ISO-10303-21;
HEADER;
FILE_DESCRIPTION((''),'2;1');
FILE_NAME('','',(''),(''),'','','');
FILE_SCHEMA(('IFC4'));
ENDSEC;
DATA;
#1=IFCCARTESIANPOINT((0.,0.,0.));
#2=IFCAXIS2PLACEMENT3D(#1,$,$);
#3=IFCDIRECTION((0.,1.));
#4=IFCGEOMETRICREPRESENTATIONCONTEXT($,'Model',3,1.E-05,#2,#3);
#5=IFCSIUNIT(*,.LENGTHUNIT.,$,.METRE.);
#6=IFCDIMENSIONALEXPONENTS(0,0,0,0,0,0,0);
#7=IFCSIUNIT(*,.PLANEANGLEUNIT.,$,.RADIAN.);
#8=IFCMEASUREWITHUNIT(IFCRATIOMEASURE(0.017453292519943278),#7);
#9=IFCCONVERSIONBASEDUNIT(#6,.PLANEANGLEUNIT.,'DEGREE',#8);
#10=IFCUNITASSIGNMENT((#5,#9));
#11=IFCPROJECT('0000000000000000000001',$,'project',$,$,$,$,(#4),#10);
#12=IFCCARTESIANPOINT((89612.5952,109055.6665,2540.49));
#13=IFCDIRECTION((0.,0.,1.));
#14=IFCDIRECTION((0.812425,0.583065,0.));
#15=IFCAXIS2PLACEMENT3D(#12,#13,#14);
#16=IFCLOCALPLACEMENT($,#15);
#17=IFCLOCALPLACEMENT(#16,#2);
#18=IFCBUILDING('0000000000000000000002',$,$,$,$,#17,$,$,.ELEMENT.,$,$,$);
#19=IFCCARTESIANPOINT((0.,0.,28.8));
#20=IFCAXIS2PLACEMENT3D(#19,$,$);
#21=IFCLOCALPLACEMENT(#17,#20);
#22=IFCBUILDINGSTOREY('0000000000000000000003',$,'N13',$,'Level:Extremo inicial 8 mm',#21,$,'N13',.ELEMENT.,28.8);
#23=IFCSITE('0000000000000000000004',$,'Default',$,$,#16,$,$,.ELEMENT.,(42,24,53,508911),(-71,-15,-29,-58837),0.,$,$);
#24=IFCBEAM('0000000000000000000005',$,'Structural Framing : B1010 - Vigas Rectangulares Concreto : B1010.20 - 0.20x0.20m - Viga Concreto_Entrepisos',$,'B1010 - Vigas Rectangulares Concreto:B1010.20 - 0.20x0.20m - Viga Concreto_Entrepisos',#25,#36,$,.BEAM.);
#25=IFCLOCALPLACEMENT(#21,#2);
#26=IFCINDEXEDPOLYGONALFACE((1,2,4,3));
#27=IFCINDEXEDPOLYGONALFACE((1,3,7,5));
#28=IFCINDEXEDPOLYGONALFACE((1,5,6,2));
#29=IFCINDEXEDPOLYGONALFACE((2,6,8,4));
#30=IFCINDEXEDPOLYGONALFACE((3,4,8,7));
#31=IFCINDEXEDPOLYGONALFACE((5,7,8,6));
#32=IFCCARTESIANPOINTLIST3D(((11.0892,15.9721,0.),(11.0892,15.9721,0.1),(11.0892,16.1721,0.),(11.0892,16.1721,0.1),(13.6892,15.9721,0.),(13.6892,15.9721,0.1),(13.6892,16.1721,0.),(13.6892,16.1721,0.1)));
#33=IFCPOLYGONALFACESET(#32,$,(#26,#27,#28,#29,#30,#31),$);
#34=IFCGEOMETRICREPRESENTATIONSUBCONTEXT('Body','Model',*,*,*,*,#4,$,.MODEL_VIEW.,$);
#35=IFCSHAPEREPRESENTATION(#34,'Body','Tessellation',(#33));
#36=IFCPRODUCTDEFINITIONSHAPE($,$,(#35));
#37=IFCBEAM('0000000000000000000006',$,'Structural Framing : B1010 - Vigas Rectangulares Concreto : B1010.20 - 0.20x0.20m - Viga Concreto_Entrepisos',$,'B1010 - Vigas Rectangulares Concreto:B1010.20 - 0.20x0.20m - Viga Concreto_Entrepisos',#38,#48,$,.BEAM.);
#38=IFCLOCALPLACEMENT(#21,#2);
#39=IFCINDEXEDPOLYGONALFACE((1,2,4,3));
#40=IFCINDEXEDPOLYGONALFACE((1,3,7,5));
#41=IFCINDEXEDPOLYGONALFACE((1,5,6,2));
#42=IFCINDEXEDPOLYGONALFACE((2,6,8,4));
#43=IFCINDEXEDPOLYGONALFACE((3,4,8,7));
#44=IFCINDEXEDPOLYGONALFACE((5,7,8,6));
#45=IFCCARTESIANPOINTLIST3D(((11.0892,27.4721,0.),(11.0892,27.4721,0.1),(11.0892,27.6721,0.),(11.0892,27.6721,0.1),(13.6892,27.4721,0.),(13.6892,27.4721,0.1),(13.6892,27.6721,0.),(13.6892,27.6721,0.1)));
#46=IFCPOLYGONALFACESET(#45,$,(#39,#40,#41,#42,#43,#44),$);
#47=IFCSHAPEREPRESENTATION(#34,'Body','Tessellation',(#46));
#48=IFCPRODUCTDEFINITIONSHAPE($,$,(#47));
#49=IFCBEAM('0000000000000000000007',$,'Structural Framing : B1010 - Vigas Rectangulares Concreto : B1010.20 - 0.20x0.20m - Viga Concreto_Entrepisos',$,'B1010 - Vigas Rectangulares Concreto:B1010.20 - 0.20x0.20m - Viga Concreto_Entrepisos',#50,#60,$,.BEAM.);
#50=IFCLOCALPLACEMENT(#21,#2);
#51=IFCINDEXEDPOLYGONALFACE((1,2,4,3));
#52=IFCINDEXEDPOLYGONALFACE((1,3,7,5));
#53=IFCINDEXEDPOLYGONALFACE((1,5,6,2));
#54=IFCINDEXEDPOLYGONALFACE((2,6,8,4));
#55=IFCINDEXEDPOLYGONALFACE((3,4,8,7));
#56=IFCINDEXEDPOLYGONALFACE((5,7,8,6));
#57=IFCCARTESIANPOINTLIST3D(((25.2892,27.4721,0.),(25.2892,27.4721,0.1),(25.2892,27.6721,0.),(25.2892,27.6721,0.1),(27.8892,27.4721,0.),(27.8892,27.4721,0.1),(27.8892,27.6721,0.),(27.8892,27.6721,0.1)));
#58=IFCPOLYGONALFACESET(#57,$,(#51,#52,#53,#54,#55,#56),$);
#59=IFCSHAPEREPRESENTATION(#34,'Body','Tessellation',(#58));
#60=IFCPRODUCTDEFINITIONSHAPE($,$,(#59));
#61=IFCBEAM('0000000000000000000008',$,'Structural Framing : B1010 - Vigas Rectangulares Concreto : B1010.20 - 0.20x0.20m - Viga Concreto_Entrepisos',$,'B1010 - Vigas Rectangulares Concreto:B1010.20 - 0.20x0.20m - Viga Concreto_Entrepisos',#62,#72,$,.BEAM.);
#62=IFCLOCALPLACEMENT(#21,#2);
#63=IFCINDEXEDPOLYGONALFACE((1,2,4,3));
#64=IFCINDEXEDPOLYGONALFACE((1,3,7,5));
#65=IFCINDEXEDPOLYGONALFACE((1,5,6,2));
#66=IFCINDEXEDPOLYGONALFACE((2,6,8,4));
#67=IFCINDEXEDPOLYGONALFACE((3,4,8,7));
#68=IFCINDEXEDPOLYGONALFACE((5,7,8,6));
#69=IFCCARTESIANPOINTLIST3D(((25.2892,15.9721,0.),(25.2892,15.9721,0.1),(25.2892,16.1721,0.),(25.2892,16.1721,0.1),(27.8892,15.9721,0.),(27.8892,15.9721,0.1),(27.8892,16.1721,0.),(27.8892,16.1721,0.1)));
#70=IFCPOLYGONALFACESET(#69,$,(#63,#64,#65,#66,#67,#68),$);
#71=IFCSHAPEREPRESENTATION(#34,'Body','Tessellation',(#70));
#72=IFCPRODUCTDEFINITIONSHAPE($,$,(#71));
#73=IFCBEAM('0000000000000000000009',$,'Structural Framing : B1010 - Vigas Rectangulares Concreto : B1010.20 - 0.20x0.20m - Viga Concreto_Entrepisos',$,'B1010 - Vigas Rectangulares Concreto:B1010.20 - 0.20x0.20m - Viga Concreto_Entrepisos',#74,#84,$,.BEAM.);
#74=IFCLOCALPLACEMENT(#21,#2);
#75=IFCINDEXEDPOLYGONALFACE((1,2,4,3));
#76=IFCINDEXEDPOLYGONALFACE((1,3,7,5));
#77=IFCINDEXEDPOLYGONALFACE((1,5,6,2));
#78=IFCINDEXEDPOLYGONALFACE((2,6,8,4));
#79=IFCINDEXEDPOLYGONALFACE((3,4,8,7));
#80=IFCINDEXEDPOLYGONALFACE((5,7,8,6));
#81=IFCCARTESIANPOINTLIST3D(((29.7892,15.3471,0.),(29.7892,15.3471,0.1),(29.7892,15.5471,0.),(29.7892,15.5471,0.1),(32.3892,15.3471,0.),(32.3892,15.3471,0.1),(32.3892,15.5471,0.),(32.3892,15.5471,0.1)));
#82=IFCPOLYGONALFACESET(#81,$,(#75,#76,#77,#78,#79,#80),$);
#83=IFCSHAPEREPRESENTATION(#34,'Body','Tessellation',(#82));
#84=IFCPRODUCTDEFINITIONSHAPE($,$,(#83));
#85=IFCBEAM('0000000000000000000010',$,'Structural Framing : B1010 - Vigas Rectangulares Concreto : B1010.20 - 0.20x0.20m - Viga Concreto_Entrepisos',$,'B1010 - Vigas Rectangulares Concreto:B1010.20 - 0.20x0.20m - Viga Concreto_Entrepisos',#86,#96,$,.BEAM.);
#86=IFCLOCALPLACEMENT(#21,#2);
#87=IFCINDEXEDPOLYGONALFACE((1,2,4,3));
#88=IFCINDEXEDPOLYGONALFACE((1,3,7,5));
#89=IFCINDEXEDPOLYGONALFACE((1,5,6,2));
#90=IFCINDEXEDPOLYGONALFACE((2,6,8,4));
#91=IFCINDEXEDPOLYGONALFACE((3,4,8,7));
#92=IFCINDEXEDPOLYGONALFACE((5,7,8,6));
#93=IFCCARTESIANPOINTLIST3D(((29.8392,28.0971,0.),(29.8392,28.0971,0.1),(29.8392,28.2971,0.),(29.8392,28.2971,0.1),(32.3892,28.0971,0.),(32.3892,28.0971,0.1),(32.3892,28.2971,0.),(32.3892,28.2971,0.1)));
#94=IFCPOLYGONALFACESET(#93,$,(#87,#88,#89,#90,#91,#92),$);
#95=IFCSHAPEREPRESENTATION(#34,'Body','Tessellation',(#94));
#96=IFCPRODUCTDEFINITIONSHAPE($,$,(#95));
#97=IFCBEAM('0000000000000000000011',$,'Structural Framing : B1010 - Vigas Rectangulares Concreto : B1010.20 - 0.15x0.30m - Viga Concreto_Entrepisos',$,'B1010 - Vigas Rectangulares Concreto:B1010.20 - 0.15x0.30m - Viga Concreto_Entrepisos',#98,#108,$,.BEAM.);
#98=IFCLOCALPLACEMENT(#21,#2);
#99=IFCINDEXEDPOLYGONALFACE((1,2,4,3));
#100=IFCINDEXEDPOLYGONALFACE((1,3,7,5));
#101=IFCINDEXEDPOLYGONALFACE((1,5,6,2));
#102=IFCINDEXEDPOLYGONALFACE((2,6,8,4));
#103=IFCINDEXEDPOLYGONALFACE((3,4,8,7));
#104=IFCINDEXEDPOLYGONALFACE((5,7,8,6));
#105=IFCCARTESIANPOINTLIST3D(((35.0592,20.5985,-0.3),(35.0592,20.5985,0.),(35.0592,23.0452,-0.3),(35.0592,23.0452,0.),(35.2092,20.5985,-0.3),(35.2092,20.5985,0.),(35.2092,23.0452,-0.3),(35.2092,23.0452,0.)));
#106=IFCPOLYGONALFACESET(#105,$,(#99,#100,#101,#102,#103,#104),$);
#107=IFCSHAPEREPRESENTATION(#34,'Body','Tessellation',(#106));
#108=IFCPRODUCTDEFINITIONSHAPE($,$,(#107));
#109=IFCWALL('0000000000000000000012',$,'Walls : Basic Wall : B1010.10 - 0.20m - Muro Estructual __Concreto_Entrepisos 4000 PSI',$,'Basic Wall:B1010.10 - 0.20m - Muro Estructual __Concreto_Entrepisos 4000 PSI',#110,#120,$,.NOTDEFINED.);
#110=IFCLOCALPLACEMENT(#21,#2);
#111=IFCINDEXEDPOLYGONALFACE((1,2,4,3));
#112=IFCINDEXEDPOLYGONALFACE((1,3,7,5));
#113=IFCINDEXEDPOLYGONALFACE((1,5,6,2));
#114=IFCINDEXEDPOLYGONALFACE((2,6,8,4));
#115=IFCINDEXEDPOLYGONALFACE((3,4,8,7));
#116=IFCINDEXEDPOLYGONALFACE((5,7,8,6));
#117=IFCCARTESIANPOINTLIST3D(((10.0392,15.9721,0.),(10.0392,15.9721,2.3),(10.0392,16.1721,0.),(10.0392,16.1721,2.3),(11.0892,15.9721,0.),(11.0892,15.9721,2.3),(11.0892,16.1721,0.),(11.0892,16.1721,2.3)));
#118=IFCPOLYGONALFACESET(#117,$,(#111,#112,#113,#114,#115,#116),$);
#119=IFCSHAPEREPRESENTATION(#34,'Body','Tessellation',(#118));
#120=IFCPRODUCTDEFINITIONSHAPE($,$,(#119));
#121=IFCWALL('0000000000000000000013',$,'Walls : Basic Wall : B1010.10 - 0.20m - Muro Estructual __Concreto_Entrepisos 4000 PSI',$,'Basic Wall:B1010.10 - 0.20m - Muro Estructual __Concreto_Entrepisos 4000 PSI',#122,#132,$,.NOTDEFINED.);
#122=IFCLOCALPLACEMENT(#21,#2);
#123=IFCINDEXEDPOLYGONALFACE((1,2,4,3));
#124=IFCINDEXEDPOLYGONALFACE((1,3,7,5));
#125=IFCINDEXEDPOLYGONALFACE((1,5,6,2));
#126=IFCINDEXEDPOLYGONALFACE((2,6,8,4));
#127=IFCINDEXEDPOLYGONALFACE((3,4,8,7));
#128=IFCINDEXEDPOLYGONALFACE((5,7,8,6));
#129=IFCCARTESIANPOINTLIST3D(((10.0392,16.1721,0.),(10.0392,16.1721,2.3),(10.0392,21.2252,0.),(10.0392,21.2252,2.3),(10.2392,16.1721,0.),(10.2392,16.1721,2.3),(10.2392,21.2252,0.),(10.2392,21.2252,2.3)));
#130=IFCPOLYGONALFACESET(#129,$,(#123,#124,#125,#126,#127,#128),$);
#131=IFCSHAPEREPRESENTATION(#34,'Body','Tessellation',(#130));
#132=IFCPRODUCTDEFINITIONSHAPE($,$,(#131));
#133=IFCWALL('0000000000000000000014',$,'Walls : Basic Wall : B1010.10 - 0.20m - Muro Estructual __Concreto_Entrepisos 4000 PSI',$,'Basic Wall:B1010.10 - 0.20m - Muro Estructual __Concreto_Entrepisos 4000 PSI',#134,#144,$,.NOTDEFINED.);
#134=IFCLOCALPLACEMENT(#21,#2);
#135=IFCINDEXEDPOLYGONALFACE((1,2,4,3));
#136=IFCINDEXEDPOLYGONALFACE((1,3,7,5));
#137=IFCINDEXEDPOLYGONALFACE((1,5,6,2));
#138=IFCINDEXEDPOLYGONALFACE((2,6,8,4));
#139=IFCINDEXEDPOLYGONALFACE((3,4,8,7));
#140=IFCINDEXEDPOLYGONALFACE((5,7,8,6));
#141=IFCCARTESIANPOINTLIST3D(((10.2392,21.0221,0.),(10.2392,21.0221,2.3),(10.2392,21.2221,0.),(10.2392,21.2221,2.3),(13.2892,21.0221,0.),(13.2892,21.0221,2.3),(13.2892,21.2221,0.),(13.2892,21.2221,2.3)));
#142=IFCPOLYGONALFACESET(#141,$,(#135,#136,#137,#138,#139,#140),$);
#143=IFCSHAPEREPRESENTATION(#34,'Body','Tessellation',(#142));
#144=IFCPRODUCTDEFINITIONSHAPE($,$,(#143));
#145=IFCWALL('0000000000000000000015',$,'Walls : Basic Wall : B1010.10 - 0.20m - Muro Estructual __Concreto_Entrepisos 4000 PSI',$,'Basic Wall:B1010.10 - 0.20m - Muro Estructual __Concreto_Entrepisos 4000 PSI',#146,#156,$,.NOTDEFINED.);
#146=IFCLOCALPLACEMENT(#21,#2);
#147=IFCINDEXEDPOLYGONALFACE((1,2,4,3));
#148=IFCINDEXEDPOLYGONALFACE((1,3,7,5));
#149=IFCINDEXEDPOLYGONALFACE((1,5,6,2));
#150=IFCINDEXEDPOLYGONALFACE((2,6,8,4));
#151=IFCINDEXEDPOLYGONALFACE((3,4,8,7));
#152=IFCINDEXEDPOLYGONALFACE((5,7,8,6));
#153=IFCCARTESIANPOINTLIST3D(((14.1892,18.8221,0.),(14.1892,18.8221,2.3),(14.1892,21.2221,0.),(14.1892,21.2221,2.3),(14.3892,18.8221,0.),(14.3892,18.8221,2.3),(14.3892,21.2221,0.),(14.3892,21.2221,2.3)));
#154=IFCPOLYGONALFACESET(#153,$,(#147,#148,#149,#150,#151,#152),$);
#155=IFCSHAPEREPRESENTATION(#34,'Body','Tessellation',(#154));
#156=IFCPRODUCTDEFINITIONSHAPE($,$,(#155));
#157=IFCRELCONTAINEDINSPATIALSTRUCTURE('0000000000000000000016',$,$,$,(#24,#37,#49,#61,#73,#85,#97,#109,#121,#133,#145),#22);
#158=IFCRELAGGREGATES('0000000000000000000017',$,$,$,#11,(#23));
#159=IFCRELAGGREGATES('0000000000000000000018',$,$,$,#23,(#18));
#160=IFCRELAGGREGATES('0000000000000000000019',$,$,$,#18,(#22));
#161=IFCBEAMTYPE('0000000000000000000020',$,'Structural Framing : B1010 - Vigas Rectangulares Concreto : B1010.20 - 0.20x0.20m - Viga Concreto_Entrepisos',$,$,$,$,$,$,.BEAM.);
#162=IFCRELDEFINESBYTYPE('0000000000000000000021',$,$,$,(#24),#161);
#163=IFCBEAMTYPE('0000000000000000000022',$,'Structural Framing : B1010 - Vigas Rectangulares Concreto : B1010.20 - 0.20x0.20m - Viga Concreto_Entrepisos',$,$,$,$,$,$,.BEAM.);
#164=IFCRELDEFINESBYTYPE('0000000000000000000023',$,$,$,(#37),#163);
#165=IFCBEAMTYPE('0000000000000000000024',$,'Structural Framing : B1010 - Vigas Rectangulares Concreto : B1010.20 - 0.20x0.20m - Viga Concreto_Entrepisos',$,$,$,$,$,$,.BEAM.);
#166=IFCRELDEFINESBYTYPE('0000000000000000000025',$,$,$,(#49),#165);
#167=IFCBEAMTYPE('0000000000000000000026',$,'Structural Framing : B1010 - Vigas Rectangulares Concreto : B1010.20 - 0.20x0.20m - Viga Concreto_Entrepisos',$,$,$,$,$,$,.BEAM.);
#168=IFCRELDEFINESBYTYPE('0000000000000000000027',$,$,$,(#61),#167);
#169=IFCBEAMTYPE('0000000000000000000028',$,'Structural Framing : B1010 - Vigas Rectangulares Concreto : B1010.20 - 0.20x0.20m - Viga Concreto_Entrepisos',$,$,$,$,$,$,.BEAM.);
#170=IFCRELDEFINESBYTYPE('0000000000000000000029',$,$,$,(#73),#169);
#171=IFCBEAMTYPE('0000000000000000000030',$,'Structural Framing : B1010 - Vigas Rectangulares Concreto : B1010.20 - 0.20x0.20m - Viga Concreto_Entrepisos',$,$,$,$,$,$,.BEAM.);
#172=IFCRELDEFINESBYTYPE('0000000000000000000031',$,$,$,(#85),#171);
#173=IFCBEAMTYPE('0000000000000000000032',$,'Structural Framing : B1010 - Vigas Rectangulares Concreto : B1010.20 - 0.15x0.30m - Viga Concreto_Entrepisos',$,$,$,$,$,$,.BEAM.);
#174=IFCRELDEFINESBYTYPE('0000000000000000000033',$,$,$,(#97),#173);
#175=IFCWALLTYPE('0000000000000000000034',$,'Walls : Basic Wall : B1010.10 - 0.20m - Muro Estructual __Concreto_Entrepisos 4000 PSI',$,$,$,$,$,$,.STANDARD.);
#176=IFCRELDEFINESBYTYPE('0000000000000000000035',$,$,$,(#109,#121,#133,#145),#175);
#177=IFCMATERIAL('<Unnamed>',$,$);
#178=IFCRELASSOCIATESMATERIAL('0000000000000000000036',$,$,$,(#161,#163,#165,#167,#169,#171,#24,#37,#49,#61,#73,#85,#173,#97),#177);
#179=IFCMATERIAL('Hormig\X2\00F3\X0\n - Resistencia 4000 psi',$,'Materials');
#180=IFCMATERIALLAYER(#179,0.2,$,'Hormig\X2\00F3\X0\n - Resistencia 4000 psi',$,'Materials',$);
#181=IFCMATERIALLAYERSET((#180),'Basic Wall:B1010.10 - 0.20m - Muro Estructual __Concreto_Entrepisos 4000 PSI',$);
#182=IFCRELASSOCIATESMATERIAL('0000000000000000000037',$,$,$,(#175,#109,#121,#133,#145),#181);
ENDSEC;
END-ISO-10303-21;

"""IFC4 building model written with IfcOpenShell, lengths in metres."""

from ifc_helpers import new_model, entity, si_unit, converted_unit, direction, frame, frame_2d, origin, place, context, subcontext, project, spatial, polyline, segment, composite_curve, rectangle, outline, extrude, source, transform, mapped, material, layer, layer_set, layer_usage, material_profile, profile_set, profile_usage, type_object, type_shapes, element, save


model = new_model("IFC4")

# Units and contexts
model_context = context("Model", 3, precision=1e-05, world=origin(), true_north=direction((0.0, 1.0)))
body_context = subcontext(model_context, "Body", "Model", "MODEL_VIEW")
ifc_project = project(units=[si_unit("LENGTHUNIT", "METRE"), converted_unit("PLANEANGLEUNIT", "DEGREE", entity("IfcRatioMeasure", 0.017453292519943278), si_unit("PLANEANGLEUNIT", "RADIAN"), dimensions=[0, 0, 0, 0, 0, 0, 0])], contexts=[model_context])

# Site, building, storey
site_placement = place(None, frame((89612.5952, 109055.6665, 2540.49), z_axis=(0.0, 0.0, 1.0), x_axis=(0.812425, 0.583065, 0.0)))
site = spatial("IfcSite", under=ifc_project, at=site_placement, Name="Default", CompositionType="ELEMENT", RefLatitude=(42, 24, 53, 508911), RefLongitude=(-71, -15, -29, -58837), RefElevation=0.0)
building_placement = place(site_placement, origin())
building = spatial("IfcBuilding", under=site, at=building_placement, CompositionType="ELEMENT")
storey_placement = place(building_placement, frame((0.0, 0.0, 28.8)))
storey = spatial("IfcBuildingStorey", under=building, at=storey_placement, Name="N13", ObjectType="Level:Extremo inicial 8 mm", LongName="N13", CompositionType="ELEMENT", Elevation=28.8)

# Beams
ifc_material_1 = material(Name="<Unnamed>")
ifc_material_profile_1 = material_profile(ifc_material_1, outline(composite_curve([segment(polyline([(-0.1, 0.0, 0.0), (-0.1, 0.1, 0.0)]), True, "CONTINUOUS"), segment(polyline([(-0.1, 0.1, 0.0), (0.1, 0.1, 0.0)]), True, "CONTINUOUS"), segment(polyline([(0.1, 0.1, 0.0), (0.1, 0.0, 0.0)]), True, "CONTINUOUS"), segment(polyline([(0.1, 0.0, 0.0), (-0.1, 0.0, 0.0)]), True, "CONTINUOUS")], self_intersect=False), kind="CURVE"), Name="B1010.20 - 0.20x0.20m - Viga Concreto_Entrepisos")
ifc_material_profile_2 = material_profile(ifc_material_1, outline(composite_curve([segment(polyline([(-1.3, -0.1, 0.1), (-1.3, 0.1, 0.1)]), True, "CONTINUOUS"), segment(polyline([(-1.3, 0.1, 0.1), (-1.3, 0.1, -0.1)]), True, "CONTINUOUS"), segment(polyline([(-1.3, 0.1, -0.1), (-1.3, -0.1, -0.1)]), True, "CONTINUOUS"), segment(polyline([(-1.3, -0.1, -0.1), (-1.3, -0.1, 0.1)]), True, "CONTINUOUS")], self_intersect=False), kind="CURVE"), Name="B1010.20 - 0.20x0.20m - Viga Concreto_Entrepisos")
ifc_profile_set_1 = profile_set([ifc_material_profile_1, ifc_material_profile_2], Name="B1010.20 - 0.20x0.20m - Viga Concreto_Entrepisos")
ifc_profile_usage_1 = profile_usage(ifc_profile_set_1, cardinal=8)
beam_type_1 = type_object("IfcBeamType", Name="Structural Framing : B1010 - Vigas Rectangulares Concreto : B1010.20 - 0.20x0.20m - Viga Concreto_Entrepisos", PredefinedType="BEAM", material=ifc_profile_set_1)
shared_shape_1 = source(origin(), body_context, "Body", "SweptSolid", [
    extrude(rectangle(XDim=0.1, YDim=0.2, at=frame_2d((0.0, 0.0), x_axis=(1.0, 0.0))), frame((13.6892, 16.0721, 28.85), z_axis=(-1.0, 0.0, 0.0), x_axis=(0.0, 0.0, -1.0)), (0.0, 0.0, 1.0), 2.6),
])
type_shapes(beam_type_1, [shared_shape_1])
beam_1_placement = place(storey_placement, frame((0.0, 0.0, -28.8)))
element("IfcBeam", 1, at=beam_1_placement, inside=storey, type_object=beam_type_1, material=ifc_profile_usage_1, Name="Structural Framing : B1010 - Vigas Rectangulares Concreto : B1010.20 - 0.20x0.20m - Viga Concreto_Entrepisos", ObjectType="B1010 - Vigas Rectangulares Concreto:B1010.20 - 0.20x0.20m - Viga Concreto_Entrepisos", PredefinedType="BEAM", context=body_context, shape_type="MappedRepresentation", body=[
    mapped(shared_shape_1, transform((0.0, 0.0, 0.0), scale=1.0)),
])
ifc_profile_usage_2 = profile_usage(ifc_profile_set_1, cardinal=8)
beam_type_2 = type_object("IfcBeamType", Name="Structural Framing : B1010 - Vigas Rectangulares Concreto : B1010.20 - 0.20x0.20m - Viga Concreto_Entrepisos", PredefinedType="BEAM", material=ifc_profile_set_1)
shared_shape_2 = source(origin(), body_context, "Body", "SweptSolid", [
    extrude(rectangle(XDim=0.1, YDim=0.2, at=frame_2d((0.0, 0.0), x_axis=(1.0, 0.0))), frame((13.6892, 27.5721, 28.85), z_axis=(-1.0, 0.0, 0.0), x_axis=(0.0, 0.0, -1.0)), (0.0, 0.0, 1.0), 2.6),
])
type_shapes(beam_type_2, [shared_shape_2])
beam_2_placement = place(storey_placement, frame((0.0, 0.0, -28.8)))
element("IfcBeam", 2, at=beam_2_placement, inside=storey, type_object=beam_type_2, material=ifc_profile_usage_2, Name="Structural Framing : B1010 - Vigas Rectangulares Concreto : B1010.20 - 0.20x0.20m - Viga Concreto_Entrepisos", ObjectType="B1010 - Vigas Rectangulares Concreto:B1010.20 - 0.20x0.20m - Viga Concreto_Entrepisos", PredefinedType="BEAM", context=body_context, shape_type="MappedRepresentation", body=[
    mapped(shared_shape_2, transform((0.0, 0.0, 0.0), scale=1.0)),
])
ifc_profile_usage_3 = profile_usage(ifc_profile_set_1, cardinal=8)
beam_type_3 = type_object("IfcBeamType", Name="Structural Framing : B1010 - Vigas Rectangulares Concreto : B1010.20 - 0.20x0.20m - Viga Concreto_Entrepisos", PredefinedType="BEAM", material=ifc_profile_set_1)
shared_shape_3 = source(origin(), body_context, "Body", "SweptSolid", [
    extrude(rectangle(XDim=0.1, YDim=0.2, at=frame_2d((0.0, 0.0), x_axis=(1.0, 0.0))), frame((25.2892, 27.5721, 28.85), z_axis=(1.0, 0.0, 0.0), x_axis=(0.0, 0.0, -1.0)), (0.0, 0.0, 1.0), 2.6),
])
type_shapes(beam_type_3, [shared_shape_3])
beam_3_placement = place(storey_placement, frame((0.0, 0.0, -28.8)))
element("IfcBeam", 3, at=beam_3_placement, inside=storey, type_object=beam_type_3, material=ifc_profile_usage_3, Name="Structural Framing : B1010 - Vigas Rectangulares Concreto : B1010.20 - 0.20x0.20m - Viga Concreto_Entrepisos", ObjectType="B1010 - Vigas Rectangulares Concreto:B1010.20 - 0.20x0.20m - Viga Concreto_Entrepisos", PredefinedType="BEAM", context=body_context, shape_type="MappedRepresentation", body=[
    mapped(shared_shape_3, transform((0.0, 0.0, 0.0), scale=1.0)),
])
ifc_profile_usage_4 = profile_usage(ifc_profile_set_1, cardinal=8)
beam_type_4 = type_object("IfcBeamType", Name="Structural Framing : B1010 - Vigas Rectangulares Concreto : B1010.20 - 0.20x0.20m - Viga Concreto_Entrepisos", PredefinedType="BEAM", material=ifc_profile_set_1)
shared_shape_4 = source(origin(), body_context, "Body", "SweptSolid", [
    extrude(rectangle(XDim=0.1, YDim=0.2, at=frame_2d((0.0, 0.0), x_axis=(1.0, 0.0))), frame((25.2892, 16.0721, 28.85), z_axis=(1.0, 0.0, 0.0), x_axis=(0.0, 0.0, -1.0)), (0.0, 0.0, 1.0), 2.6),
])
type_shapes(beam_type_4, [shared_shape_4])
beam_4_placement = place(storey_placement, frame((0.0, 0.0, -28.8)))
element("IfcBeam", 4, at=beam_4_placement, inside=storey, type_object=beam_type_4, material=ifc_profile_usage_4, Name="Structural Framing : B1010 - Vigas Rectangulares Concreto : B1010.20 - 0.20x0.20m - Viga Concreto_Entrepisos", ObjectType="B1010 - Vigas Rectangulares Concreto:B1010.20 - 0.20x0.20m - Viga Concreto_Entrepisos", PredefinedType="BEAM", context=body_context, shape_type="MappedRepresentation", body=[
    mapped(shared_shape_4, transform((0.0, 0.0, 0.0), scale=1.0)),
])
ifc_profile_usage_5 = profile_usage(ifc_profile_set_1, cardinal=8)
beam_type_5 = type_object("IfcBeamType", Name="Structural Framing : B1010 - Vigas Rectangulares Concreto : B1010.20 - 0.20x0.20m - Viga Concreto_Entrepisos", PredefinedType="BEAM", material=ifc_profile_set_1)
shared_shape_5 = source(origin(), body_context, "Body", "SweptSolid", [
    extrude(rectangle(XDim=0.1, YDim=0.2, at=frame_2d((0.0, 0.0), x_axis=(1.0, 0.0))), frame((32.3892, 15.4471, 28.85), z_axis=(-1.0, 0.0, 0.0), x_axis=(0.0, 0.0, -1.0)), (0.0, 0.0, 1.0), 2.6),
])
type_shapes(beam_type_5, [shared_shape_5])
beam_5_placement = place(storey_placement, frame((0.0, 0.0, -28.8)))
element("IfcBeam", 5, at=beam_5_placement, inside=storey, type_object=beam_type_5, material=ifc_profile_usage_5, Name="Structural Framing : B1010 - Vigas Rectangulares Concreto : B1010.20 - 0.20x0.20m - Viga Concreto_Entrepisos", ObjectType="B1010 - Vigas Rectangulares Concreto:B1010.20 - 0.20x0.20m - Viga Concreto_Entrepisos", PredefinedType="BEAM", context=body_context, shape_type="MappedRepresentation", body=[
    mapped(shared_shape_5, transform((0.0, 0.0, 0.0), scale=1.0)),
])
ifc_profile_usage_6 = profile_usage(ifc_profile_set_1, cardinal=8)
beam_type_6 = type_object("IfcBeamType", Name="Structural Framing : B1010 - Vigas Rectangulares Concreto : B1010.20 - 0.20x0.20m - Viga Concreto_Entrepisos", PredefinedType="BEAM", material=ifc_profile_set_1)
shared_shape_6 = source(origin(), body_context, "Body", "SweptSolid", [
    extrude(rectangle(XDim=0.1, YDim=0.2, at=frame_2d((0.0, 0.0), x_axis=(1.0, 0.0))), frame((29.8392, 28.1971, 28.85), z_axis=(1.0, 0.0, 0.0), x_axis=(0.0, 0.0, -1.0)), (0.0, 0.0, 1.0), 2.55),
])
type_shapes(beam_type_6, [shared_shape_6])
beam_6_placement = place(storey_placement, frame((0.0, 0.0, -28.8)))
element("IfcBeam", 6, at=beam_6_placement, inside=storey, type_object=beam_type_6, material=ifc_profile_usage_6, Name="Structural Framing : B1010 - Vigas Rectangulares Concreto : B1010.20 - 0.20x0.20m - Viga Concreto_Entrepisos", ObjectType="B1010 - Vigas Rectangulares Concreto:B1010.20 - 0.20x0.20m - Viga Concreto_Entrepisos", PredefinedType="BEAM", context=body_context, shape_type="MappedRepresentation", body=[
    mapped(shared_shape_6, transform((0.0, 0.0, 0.0), scale=1.0)),
])
ifc_material_profile_3 = material_profile(ifc_material_1, outline(composite_curve([segment(polyline([(-0.075, -0.15, 0.0), (-0.075, 0.15, 0.0)]), True, "CONTINUOUS"), segment(polyline([(-0.075, 0.15, 0.0), (0.075, 0.15, 0.0)]), True, "CONTINUOUS"), segment(polyline([(0.075, 0.15, 0.0), (0.075, -0.15, 0.0)]), True, "CONTINUOUS"), segment(polyline([(0.075, -0.15, 0.0), (-0.075, -0.15, 0.0)]), True, "CONTINUOUS")], self_intersect=False), kind="CURVE"), Name="B1010.20 - 0.15x0.30m - Viga Concreto_Entrepisos")
ifc_material_profile_4 = material_profile(ifc_material_1, outline(composite_curve([segment(polyline([(1.2233, 0.075, 0.15), (1.2233, 0.075, -0.15)]), True, "CONTINUOUS"), segment(polyline([(1.2233, 0.075, -0.15), (-1.2233, 0.075, -0.15)]), True, "CONTINUOUS"), segment(polyline([(-1.2233, 0.075, -0.15), (-1.2233, 0.075, 0.15)]), True, "CONTINUOUS"), segment(polyline([(-1.2233, 0.075, 0.15), (1.2233, 0.075, 0.15)]), True, "CONTINUOUS")], self_intersect=False), kind="CURVE"), Name="B1010.20 - 0.15x0.30m - Viga Concreto_Entrepisos")
ifc_profile_set_2 = profile_set([ifc_material_profile_3, ifc_material_profile_4], Name="B1010.20 - 0.15x0.30m - Viga Concreto_Entrepisos")
ifc_profile_usage_7 = profile_usage(ifc_profile_set_2, cardinal=8)
beam_type_7 = type_object("IfcBeamType", Name="Structural Framing : B1010 - Vigas Rectangulares Concreto : B1010.20 - 0.15x0.30m - Viga Concreto_Entrepisos", PredefinedType="BEAM", material=ifc_profile_set_2)
shared_shape_7 = source(origin(), body_context, "Body", "SweptSolid", [
    extrude(rectangle(XDim=0.3, YDim=0.15, at=frame_2d((0.0, 0.0), x_axis=(0.0, 1.0))), frame((35.1342, 20.5985, 28.65), z_axis=(0.0, 1.0, 0.0), x_axis=(-1.0, 0.0, 0.0)), (0.0, 0.0, 1.0), 2.4467),
])
type_shapes(beam_type_7, [shared_shape_7])
beam_7_placement = place(storey_placement, frame((0.0, 0.0, -28.8)))
element("IfcBeam", 7, at=beam_7_placement, inside=storey, type_object=beam_type_7, material=ifc_profile_usage_7, Name="Structural Framing : B1010 - Vigas Rectangulares Concreto : B1010.20 - 0.15x0.30m - Viga Concreto_Entrepisos", ObjectType="B1010 - Vigas Rectangulares Concreto:B1010.20 - 0.15x0.30m - Viga Concreto_Entrepisos", PredefinedType="BEAM", context=body_context, shape_type="MappedRepresentation", body=[
    mapped(shared_shape_7, transform((0.0, 0.0, 0.0), scale=1.0)),
])

# Walls
ifc_material_2 = material(Name="Hormigón - Resistencia 4000 psi", Category="Materials")
ifc_layer_1 = layer(ifc_material_2, 0.2, Name="Hormigón - Resistencia 4000 psi", Category="Materials")
ifc_layer_set_1 = layer_set([ifc_layer_1], Name="Basic Wall:B1010.10 - 0.20m - Muro Estructual __Concreto_Entrepisos 4000 PSI")
ifc_layer_usage_1 = layer_usage(ifc_layer_set_1, "AXIS2", "NEGATIVE", 0.1)
wall_type_1 = type_object("IfcWallType", Name="Walls : Basic Wall : B1010.10 - 0.20m - Muro Estructual __Concreto_Entrepisos 4000 PSI", PredefinedType="STANDARD", material=ifc_layer_set_1)
wall_1_placement = place(storey_placement, frame((11.0892, 16.0721, 0.0), z_axis=(0.0, 0.0, 1.0), x_axis=(-1.0, 0.0, 0.0)))
element("IfcWall", 8, at=wall_1_placement, inside=storey, type_object=wall_type_1, material=ifc_layer_usage_1, Name="Walls : Basic Wall : B1010.10 - 0.20m - Muro Estructual __Concreto_Entrepisos 4000 PSI", ObjectType="Basic Wall:B1010.10 - 0.20m - Muro Estructual __Concreto_Entrepisos 4000 PSI", PredefinedType="NOTDEFINED", context=body_context, shape_type="SweptSolid", body=[
    extrude(rectangle(XDim=1.05, YDim=0.2, at=frame_2d((0.525, 0.0), x_axis=(-1.0, 0.0))), origin(), (0.0, 0.0, 1.0), 2.3),
])
ifc_layer_usage_2 = layer_usage(ifc_layer_set_1, "AXIS2", "NEGATIVE", 0.1)
wall_2_placement = place(storey_placement, frame((10.1392, 16.1721, 0.0), z_axis=(0.0, 0.0, 1.0), x_axis=(0.0, 1.0, 0.0)))
element("IfcWall", 9, at=wall_2_placement, inside=storey, type_object=wall_type_1, material=ifc_layer_usage_2, Name="Walls : Basic Wall : B1010.10 - 0.20m - Muro Estructual __Concreto_Entrepisos 4000 PSI", ObjectType="Basic Wall:B1010.10 - 0.20m - Muro Estructual __Concreto_Entrepisos 4000 PSI", PredefinedType="NOTDEFINED", context=body_context, shape_type="SweptSolid", body=[
    extrude(rectangle(XDim=5.0531, YDim=0.2, at=frame_2d((2.5265, 0.0), x_axis=(-1.0, 0.0))), origin(), (0.0, 0.0, 1.0), 2.3),
])
ifc_layer_usage_3 = layer_usage(ifc_layer_set_1, "AXIS2", "NEGATIVE", 0.1)
wall_3_placement = place(storey_placement, frame((10.2392, 21.1221, 0.0)))
element("IfcWall", 10, at=wall_3_placement, inside=storey, type_object=wall_type_1, material=ifc_layer_usage_3, Name="Walls : Basic Wall : B1010.10 - 0.20m - Muro Estructual __Concreto_Entrepisos 4000 PSI", ObjectType="Basic Wall:B1010.10 - 0.20m - Muro Estructual __Concreto_Entrepisos 4000 PSI", PredefinedType="NOTDEFINED", context=body_context, shape_type="SweptSolid", body=[
    extrude(rectangle(XDim=3.05, YDim=0.2, at=frame_2d((1.525, 0.0), x_axis=(-1.0, 0.0))), origin(), (0.0, 0.0, 1.0), 2.3),
])
ifc_layer_usage_4 = layer_usage(ifc_layer_set_1, "AXIS2", "NEGATIVE", 0.1)
wall_4_placement = place(storey_placement, frame((14.2892, 18.8221, 0.0), z_axis=(0.0, 0.0, 1.0), x_axis=(0.0, 1.0, 0.0)))
element("IfcWall", 11, at=wall_4_placement, inside=storey, type_object=wall_type_1, material=ifc_layer_usage_4, Name="Walls : Basic Wall : B1010.10 - 0.20m - Muro Estructual __Concreto_Entrepisos 4000 PSI", ObjectType="Basic Wall:B1010.10 - 0.20m - Muro Estructual __Concreto_Entrepisos 4000 PSI", PredefinedType="NOTDEFINED", context=body_context, shape_type="SweptSolid", body=[
    extrude(rectangle(XDim=2.4, YDim=0.2, at=frame_2d((1.2, 0.0), x_axis=(-1.0, 0.0))), origin(), (0.0, 0.0, 1.0), 2.3),
])

save(model, "model.ifc")
